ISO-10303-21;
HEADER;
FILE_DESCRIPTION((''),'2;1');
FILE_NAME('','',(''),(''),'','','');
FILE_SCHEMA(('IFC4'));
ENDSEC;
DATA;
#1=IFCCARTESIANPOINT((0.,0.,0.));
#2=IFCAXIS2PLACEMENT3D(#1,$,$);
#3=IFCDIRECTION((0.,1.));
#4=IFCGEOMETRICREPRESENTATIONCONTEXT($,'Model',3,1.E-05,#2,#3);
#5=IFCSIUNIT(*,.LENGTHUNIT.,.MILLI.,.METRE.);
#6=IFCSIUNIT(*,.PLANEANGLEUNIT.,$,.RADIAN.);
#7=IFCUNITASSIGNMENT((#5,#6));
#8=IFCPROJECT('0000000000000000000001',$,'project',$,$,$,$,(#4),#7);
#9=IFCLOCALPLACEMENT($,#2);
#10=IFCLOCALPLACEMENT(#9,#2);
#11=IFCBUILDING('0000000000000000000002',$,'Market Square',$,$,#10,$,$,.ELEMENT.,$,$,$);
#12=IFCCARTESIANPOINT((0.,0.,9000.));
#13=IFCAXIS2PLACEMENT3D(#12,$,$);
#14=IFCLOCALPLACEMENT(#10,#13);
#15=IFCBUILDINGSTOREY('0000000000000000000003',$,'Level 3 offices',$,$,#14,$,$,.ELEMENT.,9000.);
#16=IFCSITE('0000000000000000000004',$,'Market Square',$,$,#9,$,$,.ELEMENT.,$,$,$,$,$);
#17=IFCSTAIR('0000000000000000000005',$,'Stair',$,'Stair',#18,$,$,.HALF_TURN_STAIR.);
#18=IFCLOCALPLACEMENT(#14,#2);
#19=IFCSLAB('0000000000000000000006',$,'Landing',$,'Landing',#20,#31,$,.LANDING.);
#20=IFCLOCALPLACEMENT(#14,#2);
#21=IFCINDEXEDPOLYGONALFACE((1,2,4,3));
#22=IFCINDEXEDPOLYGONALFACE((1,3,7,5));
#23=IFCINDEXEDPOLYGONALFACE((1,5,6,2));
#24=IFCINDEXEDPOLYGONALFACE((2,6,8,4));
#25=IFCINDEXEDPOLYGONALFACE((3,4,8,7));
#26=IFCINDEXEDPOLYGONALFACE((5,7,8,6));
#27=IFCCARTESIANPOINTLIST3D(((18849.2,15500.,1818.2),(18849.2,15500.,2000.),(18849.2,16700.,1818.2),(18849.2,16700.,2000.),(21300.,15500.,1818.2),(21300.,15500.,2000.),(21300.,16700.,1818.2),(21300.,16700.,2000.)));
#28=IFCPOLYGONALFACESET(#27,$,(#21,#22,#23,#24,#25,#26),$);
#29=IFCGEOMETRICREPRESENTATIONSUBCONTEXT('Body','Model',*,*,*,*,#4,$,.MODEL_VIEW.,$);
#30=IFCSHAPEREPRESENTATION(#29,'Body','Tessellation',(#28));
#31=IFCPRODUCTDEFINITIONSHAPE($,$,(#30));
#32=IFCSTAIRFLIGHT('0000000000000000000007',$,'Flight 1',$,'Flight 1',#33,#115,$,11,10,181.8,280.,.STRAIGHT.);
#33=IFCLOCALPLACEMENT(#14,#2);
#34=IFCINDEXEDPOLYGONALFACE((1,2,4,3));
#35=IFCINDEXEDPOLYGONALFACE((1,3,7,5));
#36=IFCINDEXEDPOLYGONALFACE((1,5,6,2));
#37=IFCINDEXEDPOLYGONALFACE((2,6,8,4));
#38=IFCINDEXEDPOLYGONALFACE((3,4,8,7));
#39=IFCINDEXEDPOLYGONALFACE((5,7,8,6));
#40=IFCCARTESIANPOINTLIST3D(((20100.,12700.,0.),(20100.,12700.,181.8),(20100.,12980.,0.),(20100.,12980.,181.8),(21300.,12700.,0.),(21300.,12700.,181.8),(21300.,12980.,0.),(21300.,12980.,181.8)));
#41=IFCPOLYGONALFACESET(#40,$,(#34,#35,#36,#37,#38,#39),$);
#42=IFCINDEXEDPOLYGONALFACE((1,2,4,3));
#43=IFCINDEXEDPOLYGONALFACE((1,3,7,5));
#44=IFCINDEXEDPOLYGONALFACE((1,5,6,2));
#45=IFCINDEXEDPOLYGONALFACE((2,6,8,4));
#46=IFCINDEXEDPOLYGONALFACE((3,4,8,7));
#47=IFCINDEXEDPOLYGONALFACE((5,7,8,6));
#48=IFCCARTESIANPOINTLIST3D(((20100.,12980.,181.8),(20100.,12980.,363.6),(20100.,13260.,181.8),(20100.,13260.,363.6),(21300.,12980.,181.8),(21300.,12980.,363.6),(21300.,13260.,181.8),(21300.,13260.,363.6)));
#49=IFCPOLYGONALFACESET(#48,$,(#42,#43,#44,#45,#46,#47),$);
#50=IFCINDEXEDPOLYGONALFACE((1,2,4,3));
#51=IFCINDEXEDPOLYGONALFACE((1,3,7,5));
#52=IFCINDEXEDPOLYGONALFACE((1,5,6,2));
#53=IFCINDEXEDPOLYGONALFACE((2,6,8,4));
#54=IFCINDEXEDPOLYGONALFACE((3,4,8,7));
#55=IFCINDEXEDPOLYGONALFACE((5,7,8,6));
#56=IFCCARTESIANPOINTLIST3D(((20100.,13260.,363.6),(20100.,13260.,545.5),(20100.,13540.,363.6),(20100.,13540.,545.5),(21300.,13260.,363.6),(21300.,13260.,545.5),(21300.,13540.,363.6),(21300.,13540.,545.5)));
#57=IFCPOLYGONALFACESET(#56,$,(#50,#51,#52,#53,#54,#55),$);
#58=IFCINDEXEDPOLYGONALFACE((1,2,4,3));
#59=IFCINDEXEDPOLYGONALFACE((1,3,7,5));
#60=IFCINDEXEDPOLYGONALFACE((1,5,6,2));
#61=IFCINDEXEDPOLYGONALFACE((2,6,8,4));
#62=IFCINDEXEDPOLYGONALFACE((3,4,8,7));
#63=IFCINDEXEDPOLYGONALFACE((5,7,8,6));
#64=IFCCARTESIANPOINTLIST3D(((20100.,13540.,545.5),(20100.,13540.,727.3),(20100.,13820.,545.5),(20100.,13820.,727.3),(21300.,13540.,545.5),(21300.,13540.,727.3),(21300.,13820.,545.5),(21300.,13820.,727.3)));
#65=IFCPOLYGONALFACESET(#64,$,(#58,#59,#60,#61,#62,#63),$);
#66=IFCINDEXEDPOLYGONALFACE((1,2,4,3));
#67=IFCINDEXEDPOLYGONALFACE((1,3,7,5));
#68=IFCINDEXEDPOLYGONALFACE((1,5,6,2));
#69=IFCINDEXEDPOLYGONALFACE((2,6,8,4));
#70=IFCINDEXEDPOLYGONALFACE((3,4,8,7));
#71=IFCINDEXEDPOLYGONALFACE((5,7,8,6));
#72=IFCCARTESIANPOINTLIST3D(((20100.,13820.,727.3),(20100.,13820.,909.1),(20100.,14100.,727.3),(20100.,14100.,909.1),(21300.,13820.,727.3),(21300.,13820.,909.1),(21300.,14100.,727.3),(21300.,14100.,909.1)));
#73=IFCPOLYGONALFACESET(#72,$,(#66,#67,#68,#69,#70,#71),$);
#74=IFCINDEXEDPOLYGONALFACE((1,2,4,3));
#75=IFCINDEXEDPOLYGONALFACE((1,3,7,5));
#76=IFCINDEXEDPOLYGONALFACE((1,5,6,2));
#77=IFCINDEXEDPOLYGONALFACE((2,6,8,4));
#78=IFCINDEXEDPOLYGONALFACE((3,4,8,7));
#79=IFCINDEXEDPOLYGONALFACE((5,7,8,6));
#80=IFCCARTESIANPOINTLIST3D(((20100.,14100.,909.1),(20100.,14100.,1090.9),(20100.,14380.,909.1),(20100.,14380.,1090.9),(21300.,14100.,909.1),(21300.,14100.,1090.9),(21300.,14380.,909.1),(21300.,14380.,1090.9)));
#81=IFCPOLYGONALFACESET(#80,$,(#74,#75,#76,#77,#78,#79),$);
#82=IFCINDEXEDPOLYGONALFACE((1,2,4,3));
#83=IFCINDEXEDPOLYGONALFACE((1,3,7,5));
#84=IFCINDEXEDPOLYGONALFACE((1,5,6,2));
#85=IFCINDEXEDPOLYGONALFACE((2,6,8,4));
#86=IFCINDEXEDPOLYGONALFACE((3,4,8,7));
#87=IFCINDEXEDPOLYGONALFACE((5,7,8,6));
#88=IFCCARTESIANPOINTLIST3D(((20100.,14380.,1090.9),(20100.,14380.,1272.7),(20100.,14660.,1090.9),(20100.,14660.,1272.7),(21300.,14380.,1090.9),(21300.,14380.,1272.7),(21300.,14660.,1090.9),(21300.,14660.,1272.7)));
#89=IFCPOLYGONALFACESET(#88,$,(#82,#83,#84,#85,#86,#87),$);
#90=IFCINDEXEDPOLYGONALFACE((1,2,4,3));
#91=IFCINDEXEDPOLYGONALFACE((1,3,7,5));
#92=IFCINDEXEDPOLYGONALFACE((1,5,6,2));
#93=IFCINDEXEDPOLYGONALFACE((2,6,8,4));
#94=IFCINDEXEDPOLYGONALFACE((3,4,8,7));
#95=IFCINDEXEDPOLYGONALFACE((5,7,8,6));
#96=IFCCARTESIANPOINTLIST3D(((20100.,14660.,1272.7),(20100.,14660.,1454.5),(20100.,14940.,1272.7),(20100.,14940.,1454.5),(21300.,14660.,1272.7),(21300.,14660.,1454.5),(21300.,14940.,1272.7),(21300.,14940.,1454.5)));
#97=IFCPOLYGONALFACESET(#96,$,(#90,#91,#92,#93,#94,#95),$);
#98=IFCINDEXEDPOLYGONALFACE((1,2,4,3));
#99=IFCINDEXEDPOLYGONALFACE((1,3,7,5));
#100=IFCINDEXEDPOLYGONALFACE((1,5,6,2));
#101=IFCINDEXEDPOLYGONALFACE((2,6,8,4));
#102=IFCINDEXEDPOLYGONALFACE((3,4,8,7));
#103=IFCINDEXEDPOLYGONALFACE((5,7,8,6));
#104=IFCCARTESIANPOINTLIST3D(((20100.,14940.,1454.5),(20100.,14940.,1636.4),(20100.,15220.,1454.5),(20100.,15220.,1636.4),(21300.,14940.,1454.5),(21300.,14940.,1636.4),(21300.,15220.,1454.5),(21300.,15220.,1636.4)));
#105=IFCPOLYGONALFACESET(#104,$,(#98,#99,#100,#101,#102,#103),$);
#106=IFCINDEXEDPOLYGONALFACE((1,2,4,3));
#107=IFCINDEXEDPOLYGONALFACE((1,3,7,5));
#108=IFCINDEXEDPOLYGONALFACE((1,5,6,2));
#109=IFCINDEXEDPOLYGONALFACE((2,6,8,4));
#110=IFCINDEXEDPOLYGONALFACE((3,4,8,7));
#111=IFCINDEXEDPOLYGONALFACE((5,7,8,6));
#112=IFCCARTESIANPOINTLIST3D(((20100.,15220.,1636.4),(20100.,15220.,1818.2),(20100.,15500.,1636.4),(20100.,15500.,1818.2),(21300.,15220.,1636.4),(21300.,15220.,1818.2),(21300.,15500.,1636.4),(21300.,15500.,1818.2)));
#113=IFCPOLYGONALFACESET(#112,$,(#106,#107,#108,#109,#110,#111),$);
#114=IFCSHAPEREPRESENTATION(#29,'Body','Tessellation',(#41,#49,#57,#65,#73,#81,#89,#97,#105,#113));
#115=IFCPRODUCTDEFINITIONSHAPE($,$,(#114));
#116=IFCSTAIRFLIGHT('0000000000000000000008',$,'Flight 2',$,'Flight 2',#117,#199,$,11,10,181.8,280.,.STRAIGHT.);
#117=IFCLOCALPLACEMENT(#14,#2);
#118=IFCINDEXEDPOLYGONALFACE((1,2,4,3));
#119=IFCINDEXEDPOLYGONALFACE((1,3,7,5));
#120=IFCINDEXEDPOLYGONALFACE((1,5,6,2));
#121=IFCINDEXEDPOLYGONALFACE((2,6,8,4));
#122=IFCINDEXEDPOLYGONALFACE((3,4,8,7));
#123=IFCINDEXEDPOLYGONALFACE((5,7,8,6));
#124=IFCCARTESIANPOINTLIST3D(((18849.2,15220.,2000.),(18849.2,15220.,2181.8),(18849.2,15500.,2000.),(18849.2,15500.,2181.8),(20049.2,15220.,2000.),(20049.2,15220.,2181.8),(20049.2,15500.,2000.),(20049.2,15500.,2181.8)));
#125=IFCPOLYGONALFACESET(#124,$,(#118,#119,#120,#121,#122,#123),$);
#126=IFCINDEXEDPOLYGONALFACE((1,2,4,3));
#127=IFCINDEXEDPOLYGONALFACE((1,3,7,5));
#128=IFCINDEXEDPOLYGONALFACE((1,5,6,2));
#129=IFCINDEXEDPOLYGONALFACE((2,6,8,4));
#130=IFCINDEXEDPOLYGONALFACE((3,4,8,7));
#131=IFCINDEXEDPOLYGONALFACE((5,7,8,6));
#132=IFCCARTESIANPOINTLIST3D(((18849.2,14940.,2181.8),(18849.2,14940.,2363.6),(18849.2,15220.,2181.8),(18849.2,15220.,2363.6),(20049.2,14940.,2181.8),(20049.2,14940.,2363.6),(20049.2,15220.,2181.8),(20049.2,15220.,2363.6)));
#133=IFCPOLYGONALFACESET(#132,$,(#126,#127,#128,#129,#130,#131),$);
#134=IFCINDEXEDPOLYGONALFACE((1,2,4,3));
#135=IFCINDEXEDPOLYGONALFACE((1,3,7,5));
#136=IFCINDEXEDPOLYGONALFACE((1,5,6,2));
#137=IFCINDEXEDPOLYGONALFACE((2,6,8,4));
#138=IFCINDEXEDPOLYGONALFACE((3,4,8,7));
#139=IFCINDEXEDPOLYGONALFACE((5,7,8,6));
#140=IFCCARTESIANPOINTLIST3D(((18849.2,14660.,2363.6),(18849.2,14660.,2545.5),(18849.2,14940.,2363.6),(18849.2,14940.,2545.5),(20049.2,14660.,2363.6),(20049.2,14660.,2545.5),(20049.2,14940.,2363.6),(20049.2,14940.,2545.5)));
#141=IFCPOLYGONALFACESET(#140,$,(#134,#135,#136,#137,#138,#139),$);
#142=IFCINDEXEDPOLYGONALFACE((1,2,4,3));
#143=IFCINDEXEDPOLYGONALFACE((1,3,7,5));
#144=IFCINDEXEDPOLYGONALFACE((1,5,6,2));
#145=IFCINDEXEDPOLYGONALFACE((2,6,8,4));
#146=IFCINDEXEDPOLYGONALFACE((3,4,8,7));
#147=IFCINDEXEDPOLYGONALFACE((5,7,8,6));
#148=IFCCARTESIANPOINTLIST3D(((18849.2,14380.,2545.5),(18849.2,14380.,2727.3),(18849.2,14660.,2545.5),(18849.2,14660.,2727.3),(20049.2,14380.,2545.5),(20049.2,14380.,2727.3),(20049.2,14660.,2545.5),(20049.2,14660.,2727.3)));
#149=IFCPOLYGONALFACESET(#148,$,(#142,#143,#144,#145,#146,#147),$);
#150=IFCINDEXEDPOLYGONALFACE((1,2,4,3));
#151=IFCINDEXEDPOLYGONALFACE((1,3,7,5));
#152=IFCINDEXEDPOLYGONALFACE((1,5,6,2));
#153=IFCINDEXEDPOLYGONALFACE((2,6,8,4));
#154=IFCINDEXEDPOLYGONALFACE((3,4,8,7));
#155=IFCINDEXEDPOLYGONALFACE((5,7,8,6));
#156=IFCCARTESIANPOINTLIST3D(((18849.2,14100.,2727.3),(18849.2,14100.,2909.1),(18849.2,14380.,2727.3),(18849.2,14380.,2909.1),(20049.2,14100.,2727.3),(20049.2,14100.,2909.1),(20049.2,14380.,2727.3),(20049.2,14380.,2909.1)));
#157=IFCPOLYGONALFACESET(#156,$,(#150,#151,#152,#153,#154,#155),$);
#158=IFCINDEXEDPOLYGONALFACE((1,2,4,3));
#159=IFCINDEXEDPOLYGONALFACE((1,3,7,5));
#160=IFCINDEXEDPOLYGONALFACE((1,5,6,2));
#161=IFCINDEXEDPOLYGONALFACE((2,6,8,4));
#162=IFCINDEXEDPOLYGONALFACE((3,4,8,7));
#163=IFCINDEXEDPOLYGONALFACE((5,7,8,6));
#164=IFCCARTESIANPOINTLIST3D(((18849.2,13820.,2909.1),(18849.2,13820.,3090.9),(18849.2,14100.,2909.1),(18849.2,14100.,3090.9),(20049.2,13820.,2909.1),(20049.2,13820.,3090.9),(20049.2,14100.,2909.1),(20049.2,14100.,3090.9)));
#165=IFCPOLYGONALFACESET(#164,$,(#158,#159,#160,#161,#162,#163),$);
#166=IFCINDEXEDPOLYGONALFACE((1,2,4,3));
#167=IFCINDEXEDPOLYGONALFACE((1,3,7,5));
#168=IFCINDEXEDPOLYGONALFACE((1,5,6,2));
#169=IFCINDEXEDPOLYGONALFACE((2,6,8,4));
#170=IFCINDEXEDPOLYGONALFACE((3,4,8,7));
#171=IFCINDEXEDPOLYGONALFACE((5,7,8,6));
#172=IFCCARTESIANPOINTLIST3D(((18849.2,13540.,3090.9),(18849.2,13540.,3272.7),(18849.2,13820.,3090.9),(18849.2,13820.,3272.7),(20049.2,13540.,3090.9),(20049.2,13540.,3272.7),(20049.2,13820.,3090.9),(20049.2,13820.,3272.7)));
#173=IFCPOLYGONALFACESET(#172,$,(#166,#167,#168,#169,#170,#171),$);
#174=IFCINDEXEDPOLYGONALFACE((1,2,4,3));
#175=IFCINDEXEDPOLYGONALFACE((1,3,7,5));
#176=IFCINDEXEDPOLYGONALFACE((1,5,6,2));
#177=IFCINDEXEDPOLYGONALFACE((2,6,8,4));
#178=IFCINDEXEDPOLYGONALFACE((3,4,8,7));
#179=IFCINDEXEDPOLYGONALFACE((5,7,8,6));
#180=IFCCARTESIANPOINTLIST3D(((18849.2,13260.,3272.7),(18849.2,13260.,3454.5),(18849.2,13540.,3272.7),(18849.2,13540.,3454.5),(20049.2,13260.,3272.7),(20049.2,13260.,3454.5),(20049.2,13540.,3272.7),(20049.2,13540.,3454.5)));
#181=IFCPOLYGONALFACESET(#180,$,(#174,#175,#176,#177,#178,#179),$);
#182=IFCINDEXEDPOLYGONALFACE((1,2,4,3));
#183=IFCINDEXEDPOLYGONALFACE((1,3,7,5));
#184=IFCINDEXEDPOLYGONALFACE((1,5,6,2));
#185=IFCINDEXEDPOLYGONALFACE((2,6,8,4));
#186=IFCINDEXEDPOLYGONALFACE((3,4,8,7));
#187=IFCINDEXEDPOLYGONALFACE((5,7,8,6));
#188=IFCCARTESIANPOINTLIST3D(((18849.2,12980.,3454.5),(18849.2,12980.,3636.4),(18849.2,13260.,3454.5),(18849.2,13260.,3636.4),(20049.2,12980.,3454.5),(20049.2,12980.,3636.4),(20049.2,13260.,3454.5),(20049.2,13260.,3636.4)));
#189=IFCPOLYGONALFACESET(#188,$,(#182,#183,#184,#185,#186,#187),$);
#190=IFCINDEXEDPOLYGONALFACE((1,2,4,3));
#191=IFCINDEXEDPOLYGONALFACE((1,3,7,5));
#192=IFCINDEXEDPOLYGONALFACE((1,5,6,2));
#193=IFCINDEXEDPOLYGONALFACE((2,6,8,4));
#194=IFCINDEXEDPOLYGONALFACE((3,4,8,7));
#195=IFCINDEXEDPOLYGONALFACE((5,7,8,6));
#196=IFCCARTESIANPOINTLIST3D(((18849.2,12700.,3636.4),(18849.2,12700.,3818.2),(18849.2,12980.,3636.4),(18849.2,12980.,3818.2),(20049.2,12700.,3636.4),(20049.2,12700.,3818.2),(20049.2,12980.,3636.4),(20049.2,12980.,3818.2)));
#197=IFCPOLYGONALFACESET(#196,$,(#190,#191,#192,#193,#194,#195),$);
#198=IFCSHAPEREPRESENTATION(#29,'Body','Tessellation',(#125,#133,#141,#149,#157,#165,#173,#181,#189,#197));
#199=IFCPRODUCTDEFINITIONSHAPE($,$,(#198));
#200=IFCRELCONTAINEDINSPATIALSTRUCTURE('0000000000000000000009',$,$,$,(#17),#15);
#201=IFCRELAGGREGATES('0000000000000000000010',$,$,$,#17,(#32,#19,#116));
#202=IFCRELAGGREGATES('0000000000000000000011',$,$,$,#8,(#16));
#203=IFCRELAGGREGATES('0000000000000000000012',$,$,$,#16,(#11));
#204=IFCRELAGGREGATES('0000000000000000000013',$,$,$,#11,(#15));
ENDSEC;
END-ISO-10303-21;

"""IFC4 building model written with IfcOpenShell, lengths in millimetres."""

from ifc_helpers import new_model, si_unit, direction, frame, origin, origin_with_axes, place, context, subcontext, project, spatial, polyline, outline, extrude, element, aggregate, save


model = new_model("IFC4")

# Units and contexts
model_context = context("Model", 3, precision=1e-05, world=origin(), true_north=direction((0.0, 1.0)))
body_context = subcontext(model_context, "Body", "Model", "MODEL_VIEW")
ifc_project = project(units=[si_unit("LENGTHUNIT", "METRE", prefix="MILLI"), si_unit("PLANEANGLEUNIT", "RADIAN")], contexts=[model_context])

# Site, building, storey
site_placement = place(None, origin())
site = spatial("IfcSite", under=ifc_project, at=site_placement, Name="Market Square", CompositionType="ELEMENT")
building_placement = place(site_placement, origin())
building = spatial("IfcBuilding", under=site, at=building_placement, Name="Market Square", CompositionType="ELEMENT")
storey_placement = place(building_placement, frame((0.0, 0.0, 9000.0)))
storey = spatial("IfcBuildingStorey", under=building, at=storey_placement, Name="Level 3 offices", CompositionType="ELEMENT", Elevation=9000.0)

# Stair, slab
stair_placement = place(storey_placement, origin_with_axes())
stair = element("IfcStair", 1, at=stair_placement, inside=storey, Name="Stair", ObjectType="Stair", PredefinedType="HALF_TURN_STAIR")
slab_placement = place(storey_placement, origin_with_axes())
slab = element("IfcSlab", 2, at=slab_placement, Name="Landing", ObjectType="Landing", PredefinedType="LANDING", context=body_context, shape_type="SweptSolid", body=[
    extrude(outline(polyline([(21300.0, 15500.0), (21300.0, 16700.0), (18849.2, 16700.0), (18849.2, 15500.0), (21300.0, 15500.0)])), frame((0.0, 0.0, 1818.2)), (0.0, 0.0, 1.0), 181.8),
])

# Stair flights
stair_flight_1_placement = place(storey_placement, origin_with_axes())
stair_flight_1 = element("IfcStairFlight", 3, at=stair_flight_1_placement, Name="Flight 1", ObjectType="Flight 1", NumberOfRisers=11, NumberOfTreads=10, PredefinedType="STRAIGHT", RiserHeight=181.8, TreadLength=280.0, context=body_context, shape_type="SweptSolid", body=[
    extrude(outline(polyline([(21300.0, 12700.0), (21300.0, 12980.0), (20100.0, 12980.0), (20100.0, 12700.0), (21300.0, 12700.0)])), origin(), (0.0, 0.0, 1.0), 181.8),
    extrude(outline(polyline([(21300.0, 12980.0), (21300.0, 13260.0), (20100.0, 13260.0), (20100.0, 12980.0), (21300.0, 12980.0)])), frame((0.0, 0.0, 181.8)), (0.0, 0.0, 1.0), 181.8),
    extrude(outline(polyline([(21300.0, 13260.0), (21300.0, 13540.0), (20100.0, 13540.0), (20100.0, 13260.0), (21300.0, 13260.0)])), frame((0.0, 0.0, 363.6)), (0.0, 0.0, 1.0), 181.8),
    extrude(outline(polyline([(21300.0, 13540.0), (21300.0, 13820.0), (20100.0, 13820.0), (20100.0, 13540.0), (21300.0, 13540.0)])), frame((0.0, 0.0, 545.5)), (0.0, 0.0, 1.0), 181.8),
    extrude(outline(polyline([(21300.0, 13820.0), (21300.0, 14100.0), (20100.0, 14100.0), (20100.0, 13820.0), (21300.0, 13820.0)])), frame((0.0, 0.0, 727.3)), (0.0, 0.0, 1.0), 181.8),
    extrude(outline(polyline([(21300.0, 14100.0), (21300.0, 14380.0), (20100.0, 14380.0), (20100.0, 14100.0), (21300.0, 14100.0)])), frame((0.0, 0.0, 909.1)), (0.0, 0.0, 1.0), 181.8),
    extrude(outline(polyline([(21300.0, 14380.0), (21300.0, 14660.0), (20100.0, 14660.0), (20100.0, 14380.0), (21300.0, 14380.0)])), frame((0.0, 0.0, 1090.9)), (0.0, 0.0, 1.0), 181.8),
    extrude(outline(polyline([(21300.0, 14660.0), (21300.0, 14940.0), (20100.0, 14940.0), (20100.0, 14660.0), (21300.0, 14660.0)])), frame((0.0, 0.0, 1272.7)), (0.0, 0.0, 1.0), 181.8),
    extrude(outline(polyline([(21300.0, 14940.0), (21300.0, 15220.0), (20100.0, 15220.0), (20100.0, 14940.0), (21300.0, 14940.0)])), frame((0.0, 0.0, 1454.5)), (0.0, 0.0, 1.0), 181.8),
    extrude(outline(polyline([(21300.0, 15220.0), (21300.0, 15500.0), (20100.0, 15500.0), (20100.0, 15220.0), (21300.0, 15220.0)])), frame((0.0, 0.0, 1636.4)), (0.0, 0.0, 1.0), 181.8),
])
stair_flight_2_placement = place(storey_placement, origin_with_axes())
stair_flight_2 = element("IfcStairFlight", 4, at=stair_flight_2_placement, Name="Flight 2", ObjectType="Flight 2", NumberOfRisers=11, NumberOfTreads=10, PredefinedType="STRAIGHT", RiserHeight=181.8, TreadLength=280.0, context=body_context, shape_type="SweptSolid", body=[
    extrude(outline(polyline([(20049.2, 15220.0), (20049.2, 15500.0), (18849.2, 15500.0), (18849.2, 15220.0), (20049.2, 15220.0)])), frame((0.0, 0.0, 2000.0)), (0.0, 0.0, 1.0), 181.8),
    extrude(outline(polyline([(20049.2, 14940.0), (20049.2, 15220.0), (18849.2, 15220.0), (18849.2, 14940.0), (20049.2, 14940.0)])), frame((0.0, 0.0, 2181.8)), (0.0, 0.0, 1.0), 181.8),
    extrude(outline(polyline([(20049.2, 14660.0), (20049.2, 14940.0), (18849.2, 14940.0), (18849.2, 14660.0), (20049.2, 14660.0)])), frame((0.0, 0.0, 2363.6)), (0.0, 0.0, 1.0), 181.8),
    extrude(outline(polyline([(20049.2, 14380.0), (20049.2, 14660.0), (18849.2, 14660.0), (18849.2, 14380.0), (20049.2, 14380.0)])), frame((0.0, 0.0, 2545.5)), (0.0, 0.0, 1.0), 181.8),
    extrude(outline(polyline([(20049.2, 14100.0), (20049.2, 14380.0), (18849.2, 14380.0), (18849.2, 14100.0), (20049.2, 14100.0)])), frame((0.0, 0.0, 2727.3)), (0.0, 0.0, 1.0), 181.8),
    extrude(outline(polyline([(20049.2, 13820.0), (20049.2, 14100.0), (18849.2, 14100.0), (18849.2, 13820.0), (20049.2, 13820.0)])), frame((0.0, 0.0, 2909.1)), (0.0, 0.0, 1.0), 181.8),
    extrude(outline(polyline([(20049.2, 13540.0), (20049.2, 13820.0), (18849.2, 13820.0), (18849.2, 13540.0), (20049.2, 13540.0)])), frame((0.0, 0.0, 3090.9)), (0.0, 0.0, 1.0), 181.8),
    extrude(outline(polyline([(20049.2, 13260.0), (20049.2, 13540.0), (18849.2, 13540.0), (18849.2, 13260.0), (20049.2, 13260.0)])), frame((0.0, 0.0, 3272.7)), (0.0, 0.0, 1.0), 181.8),
    extrude(outline(polyline([(20049.2, 12980.0), (20049.2, 13260.0), (18849.2, 13260.0), (18849.2, 12980.0), (20049.2, 12980.0)])), frame((0.0, 0.0, 3454.5)), (0.0, 0.0, 1.0), 181.8),
    extrude(outline(polyline([(20049.2, 12700.0), (20049.2, 12980.0), (18849.2, 12980.0), (18849.2, 12700.0), (20049.2, 12700.0)])), frame((0.0, 0.0, 3636.4)), (0.0, 0.0, 1.0), 181.8),
])
aggregate(stair, [stair_flight_1, slab, stair_flight_2])

save(model, "model.ifc")
